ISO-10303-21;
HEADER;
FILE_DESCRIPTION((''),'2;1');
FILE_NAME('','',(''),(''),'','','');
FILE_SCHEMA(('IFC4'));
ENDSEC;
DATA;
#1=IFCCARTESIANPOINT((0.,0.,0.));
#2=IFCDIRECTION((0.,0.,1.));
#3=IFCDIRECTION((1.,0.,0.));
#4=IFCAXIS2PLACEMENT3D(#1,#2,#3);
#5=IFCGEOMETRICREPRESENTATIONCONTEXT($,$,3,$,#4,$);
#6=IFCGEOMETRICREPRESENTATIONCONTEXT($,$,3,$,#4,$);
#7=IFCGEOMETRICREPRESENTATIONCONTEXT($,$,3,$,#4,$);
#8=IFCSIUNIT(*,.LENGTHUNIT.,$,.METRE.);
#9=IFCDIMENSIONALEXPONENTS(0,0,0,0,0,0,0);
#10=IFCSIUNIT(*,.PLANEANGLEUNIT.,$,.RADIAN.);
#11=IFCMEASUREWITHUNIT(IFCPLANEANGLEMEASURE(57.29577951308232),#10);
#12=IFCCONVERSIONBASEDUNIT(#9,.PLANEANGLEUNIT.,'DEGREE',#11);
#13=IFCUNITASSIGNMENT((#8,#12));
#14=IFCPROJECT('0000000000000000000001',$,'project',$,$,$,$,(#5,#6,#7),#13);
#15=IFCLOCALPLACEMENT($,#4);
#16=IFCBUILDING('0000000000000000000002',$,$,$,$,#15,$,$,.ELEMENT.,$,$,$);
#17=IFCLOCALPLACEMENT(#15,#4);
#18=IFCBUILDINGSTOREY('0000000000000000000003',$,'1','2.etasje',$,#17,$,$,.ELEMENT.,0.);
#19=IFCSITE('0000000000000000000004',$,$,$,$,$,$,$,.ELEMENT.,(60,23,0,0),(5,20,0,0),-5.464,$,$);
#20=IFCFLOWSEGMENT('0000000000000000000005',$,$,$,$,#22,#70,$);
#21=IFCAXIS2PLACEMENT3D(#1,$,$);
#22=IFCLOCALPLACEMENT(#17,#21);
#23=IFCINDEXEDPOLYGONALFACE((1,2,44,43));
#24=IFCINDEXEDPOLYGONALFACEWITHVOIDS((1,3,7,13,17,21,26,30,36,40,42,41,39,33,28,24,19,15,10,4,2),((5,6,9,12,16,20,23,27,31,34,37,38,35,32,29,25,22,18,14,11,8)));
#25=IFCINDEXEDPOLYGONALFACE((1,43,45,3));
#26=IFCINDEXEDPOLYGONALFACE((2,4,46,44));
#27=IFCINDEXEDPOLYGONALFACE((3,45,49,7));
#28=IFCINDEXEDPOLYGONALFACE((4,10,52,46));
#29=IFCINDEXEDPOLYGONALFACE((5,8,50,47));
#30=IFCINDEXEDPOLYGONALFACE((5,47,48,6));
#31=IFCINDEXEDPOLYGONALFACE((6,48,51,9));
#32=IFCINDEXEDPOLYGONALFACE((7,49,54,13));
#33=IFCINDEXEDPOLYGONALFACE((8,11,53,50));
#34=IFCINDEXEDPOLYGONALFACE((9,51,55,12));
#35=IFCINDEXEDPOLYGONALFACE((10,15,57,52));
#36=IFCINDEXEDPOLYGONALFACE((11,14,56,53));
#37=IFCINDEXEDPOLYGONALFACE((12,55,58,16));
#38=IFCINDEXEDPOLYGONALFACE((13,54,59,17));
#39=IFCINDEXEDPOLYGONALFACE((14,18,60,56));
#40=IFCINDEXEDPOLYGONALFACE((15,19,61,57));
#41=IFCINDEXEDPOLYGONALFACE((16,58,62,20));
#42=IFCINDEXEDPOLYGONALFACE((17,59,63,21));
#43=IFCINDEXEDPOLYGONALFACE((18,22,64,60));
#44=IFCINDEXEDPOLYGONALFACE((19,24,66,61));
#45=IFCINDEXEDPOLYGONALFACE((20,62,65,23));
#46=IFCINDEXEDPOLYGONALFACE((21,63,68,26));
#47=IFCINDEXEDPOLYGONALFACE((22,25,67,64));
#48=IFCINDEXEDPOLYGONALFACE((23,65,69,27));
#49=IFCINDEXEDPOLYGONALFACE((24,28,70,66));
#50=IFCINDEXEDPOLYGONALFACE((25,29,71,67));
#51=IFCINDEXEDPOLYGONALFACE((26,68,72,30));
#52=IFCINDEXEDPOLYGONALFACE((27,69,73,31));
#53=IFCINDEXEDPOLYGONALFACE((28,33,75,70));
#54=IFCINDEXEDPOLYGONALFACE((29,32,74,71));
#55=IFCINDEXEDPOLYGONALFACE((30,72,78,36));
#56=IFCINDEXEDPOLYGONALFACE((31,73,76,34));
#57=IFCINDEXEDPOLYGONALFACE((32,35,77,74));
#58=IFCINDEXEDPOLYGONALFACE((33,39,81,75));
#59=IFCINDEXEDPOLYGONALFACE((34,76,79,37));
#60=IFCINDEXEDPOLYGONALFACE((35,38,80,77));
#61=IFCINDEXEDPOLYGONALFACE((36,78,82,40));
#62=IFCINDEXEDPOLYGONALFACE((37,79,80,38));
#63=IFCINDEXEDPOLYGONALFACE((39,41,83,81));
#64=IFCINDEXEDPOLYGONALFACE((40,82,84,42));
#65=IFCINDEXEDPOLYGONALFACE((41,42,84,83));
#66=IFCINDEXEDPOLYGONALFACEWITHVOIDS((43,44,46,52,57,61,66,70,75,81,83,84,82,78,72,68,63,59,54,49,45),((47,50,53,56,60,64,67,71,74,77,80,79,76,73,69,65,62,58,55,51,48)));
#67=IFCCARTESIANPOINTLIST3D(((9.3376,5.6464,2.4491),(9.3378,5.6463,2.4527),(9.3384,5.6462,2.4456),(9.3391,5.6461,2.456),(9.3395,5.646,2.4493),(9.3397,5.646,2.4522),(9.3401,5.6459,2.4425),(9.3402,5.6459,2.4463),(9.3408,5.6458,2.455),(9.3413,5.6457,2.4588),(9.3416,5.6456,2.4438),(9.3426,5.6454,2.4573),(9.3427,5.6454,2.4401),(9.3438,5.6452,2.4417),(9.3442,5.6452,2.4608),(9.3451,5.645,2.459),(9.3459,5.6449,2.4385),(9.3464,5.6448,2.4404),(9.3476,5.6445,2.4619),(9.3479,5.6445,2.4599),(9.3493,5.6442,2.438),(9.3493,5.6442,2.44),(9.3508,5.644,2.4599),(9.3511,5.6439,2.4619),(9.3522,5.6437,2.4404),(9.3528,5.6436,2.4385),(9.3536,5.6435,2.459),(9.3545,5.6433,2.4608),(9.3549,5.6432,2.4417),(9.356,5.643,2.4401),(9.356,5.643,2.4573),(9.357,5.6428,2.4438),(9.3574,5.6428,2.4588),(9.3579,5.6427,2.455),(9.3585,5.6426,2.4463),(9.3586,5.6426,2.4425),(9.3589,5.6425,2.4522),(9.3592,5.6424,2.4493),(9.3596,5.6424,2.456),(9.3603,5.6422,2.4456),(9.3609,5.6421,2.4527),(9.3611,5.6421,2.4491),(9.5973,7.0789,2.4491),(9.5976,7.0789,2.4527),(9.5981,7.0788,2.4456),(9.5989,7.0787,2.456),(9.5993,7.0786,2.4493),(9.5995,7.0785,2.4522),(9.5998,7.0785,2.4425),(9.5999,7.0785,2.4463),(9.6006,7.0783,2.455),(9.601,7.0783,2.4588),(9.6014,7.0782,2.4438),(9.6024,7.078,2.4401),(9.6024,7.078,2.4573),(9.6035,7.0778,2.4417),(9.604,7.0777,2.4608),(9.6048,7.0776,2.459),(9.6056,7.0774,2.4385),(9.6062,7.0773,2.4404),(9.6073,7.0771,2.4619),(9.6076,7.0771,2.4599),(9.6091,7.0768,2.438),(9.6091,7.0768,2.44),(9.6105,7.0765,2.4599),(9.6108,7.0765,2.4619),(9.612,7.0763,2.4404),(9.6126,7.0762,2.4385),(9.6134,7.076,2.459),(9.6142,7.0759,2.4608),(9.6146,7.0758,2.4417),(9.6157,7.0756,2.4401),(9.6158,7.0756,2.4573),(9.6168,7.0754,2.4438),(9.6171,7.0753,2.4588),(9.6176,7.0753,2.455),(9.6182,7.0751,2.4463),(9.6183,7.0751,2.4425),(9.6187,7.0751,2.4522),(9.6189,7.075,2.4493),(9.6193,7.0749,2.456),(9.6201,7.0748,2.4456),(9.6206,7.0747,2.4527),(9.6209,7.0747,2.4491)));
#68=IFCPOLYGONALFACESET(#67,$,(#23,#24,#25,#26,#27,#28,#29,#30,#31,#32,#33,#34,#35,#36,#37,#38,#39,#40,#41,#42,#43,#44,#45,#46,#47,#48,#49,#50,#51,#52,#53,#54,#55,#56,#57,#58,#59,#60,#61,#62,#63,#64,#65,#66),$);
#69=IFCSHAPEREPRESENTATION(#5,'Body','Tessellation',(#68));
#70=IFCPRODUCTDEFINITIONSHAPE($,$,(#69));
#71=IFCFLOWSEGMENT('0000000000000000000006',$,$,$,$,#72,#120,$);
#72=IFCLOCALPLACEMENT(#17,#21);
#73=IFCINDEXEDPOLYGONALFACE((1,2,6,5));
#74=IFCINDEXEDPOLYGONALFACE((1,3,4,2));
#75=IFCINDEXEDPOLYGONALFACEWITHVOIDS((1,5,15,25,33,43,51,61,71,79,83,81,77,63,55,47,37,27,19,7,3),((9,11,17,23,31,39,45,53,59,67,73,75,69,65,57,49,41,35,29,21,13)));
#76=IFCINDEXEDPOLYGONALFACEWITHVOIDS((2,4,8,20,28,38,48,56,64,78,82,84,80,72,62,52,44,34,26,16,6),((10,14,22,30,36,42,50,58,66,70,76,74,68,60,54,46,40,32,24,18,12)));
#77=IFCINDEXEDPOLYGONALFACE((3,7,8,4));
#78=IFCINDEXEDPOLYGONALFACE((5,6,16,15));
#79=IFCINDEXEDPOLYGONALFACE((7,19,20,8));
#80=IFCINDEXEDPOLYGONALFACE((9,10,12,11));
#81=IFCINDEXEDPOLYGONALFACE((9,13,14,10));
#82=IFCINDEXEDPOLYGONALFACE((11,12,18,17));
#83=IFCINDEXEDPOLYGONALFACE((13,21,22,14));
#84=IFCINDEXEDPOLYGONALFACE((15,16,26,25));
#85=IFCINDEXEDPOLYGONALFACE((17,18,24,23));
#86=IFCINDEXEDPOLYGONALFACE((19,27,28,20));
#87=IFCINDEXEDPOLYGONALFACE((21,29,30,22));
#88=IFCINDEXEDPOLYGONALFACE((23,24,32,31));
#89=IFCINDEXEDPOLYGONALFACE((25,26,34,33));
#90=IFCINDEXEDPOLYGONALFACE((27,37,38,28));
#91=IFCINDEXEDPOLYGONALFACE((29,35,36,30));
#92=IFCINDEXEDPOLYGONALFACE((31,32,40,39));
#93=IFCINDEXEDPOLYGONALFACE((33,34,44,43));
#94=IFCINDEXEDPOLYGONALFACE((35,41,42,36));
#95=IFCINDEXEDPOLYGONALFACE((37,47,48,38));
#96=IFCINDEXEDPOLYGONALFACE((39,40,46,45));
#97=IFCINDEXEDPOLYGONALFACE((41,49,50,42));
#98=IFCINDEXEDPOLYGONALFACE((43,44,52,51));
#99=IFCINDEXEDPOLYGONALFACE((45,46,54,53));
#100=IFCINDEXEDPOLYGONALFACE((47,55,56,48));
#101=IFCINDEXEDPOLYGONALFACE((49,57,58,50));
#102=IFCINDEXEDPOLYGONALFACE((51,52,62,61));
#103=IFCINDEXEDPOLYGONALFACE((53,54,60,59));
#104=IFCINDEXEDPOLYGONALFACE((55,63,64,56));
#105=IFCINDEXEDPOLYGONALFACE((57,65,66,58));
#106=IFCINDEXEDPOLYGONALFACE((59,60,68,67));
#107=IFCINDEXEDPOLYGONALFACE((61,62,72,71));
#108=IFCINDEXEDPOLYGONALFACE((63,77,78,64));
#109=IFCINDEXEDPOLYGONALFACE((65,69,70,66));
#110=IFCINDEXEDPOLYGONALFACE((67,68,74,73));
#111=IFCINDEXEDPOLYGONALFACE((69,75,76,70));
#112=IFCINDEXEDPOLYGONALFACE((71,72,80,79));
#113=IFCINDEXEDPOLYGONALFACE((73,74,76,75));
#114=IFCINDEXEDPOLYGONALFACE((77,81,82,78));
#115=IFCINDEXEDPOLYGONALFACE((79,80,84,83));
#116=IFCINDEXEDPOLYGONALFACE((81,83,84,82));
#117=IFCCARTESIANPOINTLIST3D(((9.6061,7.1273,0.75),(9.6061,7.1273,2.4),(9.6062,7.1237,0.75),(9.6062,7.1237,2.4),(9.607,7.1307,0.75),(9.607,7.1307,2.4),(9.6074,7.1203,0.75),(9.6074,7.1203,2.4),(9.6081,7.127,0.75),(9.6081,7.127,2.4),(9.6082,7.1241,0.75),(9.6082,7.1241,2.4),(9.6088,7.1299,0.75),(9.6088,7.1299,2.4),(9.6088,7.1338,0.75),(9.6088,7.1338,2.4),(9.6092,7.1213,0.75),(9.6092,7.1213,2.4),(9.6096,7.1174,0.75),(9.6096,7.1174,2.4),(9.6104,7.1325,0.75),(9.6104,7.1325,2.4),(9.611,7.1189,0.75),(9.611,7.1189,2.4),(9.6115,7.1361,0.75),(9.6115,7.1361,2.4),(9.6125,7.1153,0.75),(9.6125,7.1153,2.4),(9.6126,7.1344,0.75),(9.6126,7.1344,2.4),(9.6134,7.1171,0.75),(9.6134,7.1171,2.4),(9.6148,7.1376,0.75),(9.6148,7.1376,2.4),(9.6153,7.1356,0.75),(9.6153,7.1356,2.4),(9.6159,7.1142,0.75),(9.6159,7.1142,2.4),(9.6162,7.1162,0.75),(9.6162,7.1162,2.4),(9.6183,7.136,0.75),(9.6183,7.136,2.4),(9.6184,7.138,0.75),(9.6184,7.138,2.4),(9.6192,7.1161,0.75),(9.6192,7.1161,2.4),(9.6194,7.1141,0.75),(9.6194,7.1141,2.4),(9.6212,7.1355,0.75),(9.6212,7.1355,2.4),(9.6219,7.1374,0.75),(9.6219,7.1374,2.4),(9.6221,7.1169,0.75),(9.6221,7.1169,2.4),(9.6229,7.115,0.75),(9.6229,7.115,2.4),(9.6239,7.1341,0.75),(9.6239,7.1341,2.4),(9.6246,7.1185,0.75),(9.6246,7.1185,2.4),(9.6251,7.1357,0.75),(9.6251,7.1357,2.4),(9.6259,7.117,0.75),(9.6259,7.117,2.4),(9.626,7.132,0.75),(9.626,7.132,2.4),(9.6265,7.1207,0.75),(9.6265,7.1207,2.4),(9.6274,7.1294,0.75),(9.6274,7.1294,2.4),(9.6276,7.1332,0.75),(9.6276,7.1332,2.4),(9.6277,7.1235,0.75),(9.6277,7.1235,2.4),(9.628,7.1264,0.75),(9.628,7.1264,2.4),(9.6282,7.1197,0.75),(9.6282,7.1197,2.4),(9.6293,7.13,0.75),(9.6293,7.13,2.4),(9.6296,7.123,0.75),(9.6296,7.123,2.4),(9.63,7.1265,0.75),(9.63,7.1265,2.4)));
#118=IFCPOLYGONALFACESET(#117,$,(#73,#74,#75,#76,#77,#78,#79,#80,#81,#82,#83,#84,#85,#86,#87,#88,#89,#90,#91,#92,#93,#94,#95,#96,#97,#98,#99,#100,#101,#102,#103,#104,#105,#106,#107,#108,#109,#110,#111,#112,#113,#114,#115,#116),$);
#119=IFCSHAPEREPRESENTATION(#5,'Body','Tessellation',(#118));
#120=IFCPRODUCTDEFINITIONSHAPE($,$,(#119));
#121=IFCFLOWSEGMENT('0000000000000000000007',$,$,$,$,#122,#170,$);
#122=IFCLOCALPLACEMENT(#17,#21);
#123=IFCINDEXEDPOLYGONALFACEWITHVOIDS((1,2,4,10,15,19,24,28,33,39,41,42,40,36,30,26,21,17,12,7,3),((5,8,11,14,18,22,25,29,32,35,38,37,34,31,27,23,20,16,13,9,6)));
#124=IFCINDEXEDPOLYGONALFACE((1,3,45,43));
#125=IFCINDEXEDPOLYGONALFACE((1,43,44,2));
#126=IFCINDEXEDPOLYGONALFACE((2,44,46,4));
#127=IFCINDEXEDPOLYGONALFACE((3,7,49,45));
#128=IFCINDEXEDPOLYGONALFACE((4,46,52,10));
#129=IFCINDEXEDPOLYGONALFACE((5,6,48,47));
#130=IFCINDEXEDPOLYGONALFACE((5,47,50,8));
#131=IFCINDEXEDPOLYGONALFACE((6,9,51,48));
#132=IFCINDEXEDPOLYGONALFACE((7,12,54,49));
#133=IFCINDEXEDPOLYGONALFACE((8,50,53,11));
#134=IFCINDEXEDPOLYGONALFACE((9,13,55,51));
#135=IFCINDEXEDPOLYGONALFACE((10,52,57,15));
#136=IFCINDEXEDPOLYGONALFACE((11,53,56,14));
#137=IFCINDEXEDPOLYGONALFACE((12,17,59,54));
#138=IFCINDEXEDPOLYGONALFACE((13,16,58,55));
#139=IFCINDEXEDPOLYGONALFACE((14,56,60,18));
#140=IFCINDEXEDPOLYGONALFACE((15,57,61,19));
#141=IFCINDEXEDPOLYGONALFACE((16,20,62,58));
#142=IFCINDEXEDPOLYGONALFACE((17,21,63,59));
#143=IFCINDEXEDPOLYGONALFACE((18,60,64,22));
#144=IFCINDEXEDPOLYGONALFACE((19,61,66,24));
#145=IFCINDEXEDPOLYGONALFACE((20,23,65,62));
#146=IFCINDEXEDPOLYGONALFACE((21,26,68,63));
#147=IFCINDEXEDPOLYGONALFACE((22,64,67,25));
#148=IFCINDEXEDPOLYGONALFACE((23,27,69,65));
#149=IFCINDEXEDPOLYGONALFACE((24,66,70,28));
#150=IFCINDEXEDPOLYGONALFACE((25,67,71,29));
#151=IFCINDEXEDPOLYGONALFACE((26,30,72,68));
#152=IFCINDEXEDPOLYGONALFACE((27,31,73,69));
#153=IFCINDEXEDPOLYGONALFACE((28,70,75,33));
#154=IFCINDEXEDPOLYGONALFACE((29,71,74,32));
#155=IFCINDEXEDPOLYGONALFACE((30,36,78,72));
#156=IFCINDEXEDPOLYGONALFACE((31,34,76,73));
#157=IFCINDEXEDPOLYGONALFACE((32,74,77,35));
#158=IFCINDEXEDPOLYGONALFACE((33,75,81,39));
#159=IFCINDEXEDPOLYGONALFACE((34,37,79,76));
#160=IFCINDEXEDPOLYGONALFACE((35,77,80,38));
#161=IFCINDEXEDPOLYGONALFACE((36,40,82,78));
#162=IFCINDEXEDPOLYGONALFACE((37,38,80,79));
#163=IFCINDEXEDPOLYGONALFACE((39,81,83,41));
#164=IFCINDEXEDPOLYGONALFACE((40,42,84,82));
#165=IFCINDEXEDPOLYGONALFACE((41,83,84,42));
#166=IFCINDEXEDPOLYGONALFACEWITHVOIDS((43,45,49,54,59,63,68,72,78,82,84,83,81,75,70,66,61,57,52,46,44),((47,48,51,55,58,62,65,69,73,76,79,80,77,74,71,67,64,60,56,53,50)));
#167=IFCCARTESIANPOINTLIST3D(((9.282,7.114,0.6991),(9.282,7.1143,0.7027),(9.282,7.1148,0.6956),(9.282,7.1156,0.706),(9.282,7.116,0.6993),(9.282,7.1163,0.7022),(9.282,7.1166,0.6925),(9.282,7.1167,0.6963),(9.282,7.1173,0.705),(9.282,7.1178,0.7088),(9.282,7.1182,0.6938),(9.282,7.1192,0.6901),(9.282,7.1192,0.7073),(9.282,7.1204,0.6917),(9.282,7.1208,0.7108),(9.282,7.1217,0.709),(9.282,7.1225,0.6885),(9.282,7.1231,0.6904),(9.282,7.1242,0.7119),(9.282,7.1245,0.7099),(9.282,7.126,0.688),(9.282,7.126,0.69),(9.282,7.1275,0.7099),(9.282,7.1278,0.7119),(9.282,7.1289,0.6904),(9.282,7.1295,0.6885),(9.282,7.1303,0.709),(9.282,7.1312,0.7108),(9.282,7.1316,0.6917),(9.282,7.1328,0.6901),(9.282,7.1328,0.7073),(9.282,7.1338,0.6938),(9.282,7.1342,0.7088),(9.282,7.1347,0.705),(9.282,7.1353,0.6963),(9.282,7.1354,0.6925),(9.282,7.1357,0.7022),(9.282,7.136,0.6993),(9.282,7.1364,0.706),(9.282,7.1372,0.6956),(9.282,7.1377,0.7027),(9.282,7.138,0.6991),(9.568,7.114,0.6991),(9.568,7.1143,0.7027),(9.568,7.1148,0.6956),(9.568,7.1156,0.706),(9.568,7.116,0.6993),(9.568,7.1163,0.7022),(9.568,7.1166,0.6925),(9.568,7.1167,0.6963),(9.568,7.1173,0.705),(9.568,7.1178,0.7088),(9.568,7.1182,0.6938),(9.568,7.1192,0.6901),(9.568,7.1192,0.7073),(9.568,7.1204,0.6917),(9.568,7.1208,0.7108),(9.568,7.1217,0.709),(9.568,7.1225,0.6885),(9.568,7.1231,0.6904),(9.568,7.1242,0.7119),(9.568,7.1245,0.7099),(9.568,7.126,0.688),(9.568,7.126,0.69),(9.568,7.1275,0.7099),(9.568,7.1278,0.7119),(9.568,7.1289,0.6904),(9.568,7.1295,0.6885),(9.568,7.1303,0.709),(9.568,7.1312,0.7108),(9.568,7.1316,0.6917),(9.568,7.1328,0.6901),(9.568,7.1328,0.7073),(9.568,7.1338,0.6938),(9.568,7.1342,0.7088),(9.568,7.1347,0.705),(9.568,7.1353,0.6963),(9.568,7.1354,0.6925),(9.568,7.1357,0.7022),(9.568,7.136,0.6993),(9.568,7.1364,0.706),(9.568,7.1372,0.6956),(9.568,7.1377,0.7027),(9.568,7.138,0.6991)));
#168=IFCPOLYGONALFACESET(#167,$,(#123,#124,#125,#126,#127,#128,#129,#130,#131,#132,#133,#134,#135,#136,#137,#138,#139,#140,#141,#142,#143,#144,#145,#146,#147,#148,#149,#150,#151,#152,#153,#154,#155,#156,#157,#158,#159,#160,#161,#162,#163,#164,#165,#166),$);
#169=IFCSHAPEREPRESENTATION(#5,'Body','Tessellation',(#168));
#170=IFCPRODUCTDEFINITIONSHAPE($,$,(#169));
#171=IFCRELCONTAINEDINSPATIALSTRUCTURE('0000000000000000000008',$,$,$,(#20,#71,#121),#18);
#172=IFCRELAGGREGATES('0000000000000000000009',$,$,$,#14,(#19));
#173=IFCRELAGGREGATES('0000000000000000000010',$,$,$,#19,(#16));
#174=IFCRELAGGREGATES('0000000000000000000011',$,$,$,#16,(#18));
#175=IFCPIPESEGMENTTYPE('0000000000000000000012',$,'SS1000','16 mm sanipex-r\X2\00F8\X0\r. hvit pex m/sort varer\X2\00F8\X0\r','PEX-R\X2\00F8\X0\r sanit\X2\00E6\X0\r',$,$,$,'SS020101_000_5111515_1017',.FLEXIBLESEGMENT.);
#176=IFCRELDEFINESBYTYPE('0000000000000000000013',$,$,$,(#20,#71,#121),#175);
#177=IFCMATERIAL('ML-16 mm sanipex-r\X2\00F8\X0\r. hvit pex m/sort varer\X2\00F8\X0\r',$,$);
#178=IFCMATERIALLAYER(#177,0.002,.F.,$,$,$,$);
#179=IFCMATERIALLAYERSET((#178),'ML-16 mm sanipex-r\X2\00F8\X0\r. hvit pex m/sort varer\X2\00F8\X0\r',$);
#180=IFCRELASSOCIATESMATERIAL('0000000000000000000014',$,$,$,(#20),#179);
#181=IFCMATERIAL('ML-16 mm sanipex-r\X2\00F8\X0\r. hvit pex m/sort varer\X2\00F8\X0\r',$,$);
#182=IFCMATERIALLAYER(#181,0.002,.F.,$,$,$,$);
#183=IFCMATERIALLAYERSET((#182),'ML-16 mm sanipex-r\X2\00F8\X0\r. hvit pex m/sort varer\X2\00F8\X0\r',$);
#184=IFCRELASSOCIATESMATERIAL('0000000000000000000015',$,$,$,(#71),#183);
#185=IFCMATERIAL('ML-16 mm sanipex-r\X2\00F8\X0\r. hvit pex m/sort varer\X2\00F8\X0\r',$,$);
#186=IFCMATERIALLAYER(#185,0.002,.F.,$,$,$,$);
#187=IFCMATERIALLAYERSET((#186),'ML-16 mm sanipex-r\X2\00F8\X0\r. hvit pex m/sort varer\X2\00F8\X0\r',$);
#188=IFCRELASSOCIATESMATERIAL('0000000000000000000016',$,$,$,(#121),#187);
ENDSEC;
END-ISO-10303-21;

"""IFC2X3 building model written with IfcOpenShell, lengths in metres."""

from ifc_helpers import new_model, entity, si_unit, converted_unit, frame, origin_with_axes, origin_2d_with_axis, place, context, project, spatial, hollow_circle, extrude, material, layer, layer_set, layer_usage, type_object, element, save


model = new_model("IFC2X3")

# Units and contexts
context_of_model_1 = context(None, 3, world=origin_with_axes())
context_of_model_2 = context(None, 3, world=origin_with_axes())
context_of_model_3 = context(None, 3, world=origin_with_axes())
ifc_project = project(units=[si_unit("LENGTHUNIT", "METRE"), converted_unit("PLANEANGLEUNIT", "DEGREE", entity("IfcPlaneAngleMeasure", 57.29577951308232), si_unit("PLANEANGLEUNIT", "RADIAN"), dimensions=[0, 0, 0, 0, 0, 0, 0])], contexts=[context_of_model_1, context_of_model_2, context_of_model_3])

# Site, building, storey
site = spatial("IfcSite", under=ifc_project, CompositionType="ELEMENT", RefLatitude=(60, 23, 0, 0), RefLongitude=(5, 20, 0, 0), RefElevation=-5.464)
building_placement = place(None, origin_with_axes())
building = spatial("IfcBuilding", under=site, at=building_placement, CompositionType="ELEMENT")
storey_placement = place(building_placement, origin_with_axes())
storey = spatial("IfcBuildingStorey", under=building, at=storey_placement, Name="1", Description="2.etasje", CompositionType="ELEMENT", Elevation=0.0)

# Flow segments
ifc_material_1 = material(Name="ML-16 mm sanipex-rør. hvit pex m/sort varerør")
ifc_layer_1 = layer(ifc_material_1, 0.002, ventilated=False)
ifc_layer_set_1 = layer_set([ifc_layer_1], Name="ML-16 mm sanipex-rør. hvit pex m/sort varerør")
ifc_layer_usage_1 = layer_usage(ifc_layer_set_1, "AXIS2", "POSITIVE", 0.0)
pipe_segment_type_1 = type_object("IfcPipeSegmentType", Name="SS1000", Description="16 mm sanipex-rør. hvit pex m/sort varerør", ApplicableOccurrence="PEX-Rør sanitær", ElementType="SS020101_000_5111515_1017", PredefinedType="FLEXIBLESEGMENT")
flow_segment_1_placement = place(storey_placement, frame((9.3493, 5.6442, 2.45), z_axis=(0.1784, 0.983958, 0.0), x_axis=(0.0, 0.0, -1.0)))
element("IfcFlowSegment", 1, at=flow_segment_1_placement, inside=storey, type_object=pipe_segment_type_1, material=ifc_layer_usage_1, context=context_of_model_1, shape_type="SweptSolid", body=[
    extrude(hollow_circle(Radius=0.012, WallThickness=0.002, at=origin_2d_with_axis()), origin_with_axes(), (0.0, 0.0, 1.0), 1.4559),
])
ifc_material_2 = material(Name="ML-16 mm sanipex-rør. hvit pex m/sort varerør")
ifc_layer_2 = layer(ifc_material_2, 0.002, ventilated=False)
ifc_layer_set_2 = layer_set([ifc_layer_2], Name="ML-16 mm sanipex-rør. hvit pex m/sort varerør")
ifc_layer_usage_2 = layer_usage(ifc_layer_set_2, "AXIS2", "POSITIVE", 0.0)
flow_segment_2_placement = place(storey_placement, frame((9.618, 7.126, 2.4), z_axis=(0.0, 0.0, -1.0), x_axis=(-0.1784, -0.983958, 0.0)))
element("IfcFlowSegment", 2, at=flow_segment_2_placement, inside=storey, type_object=pipe_segment_type_1, material=ifc_layer_usage_2, context=context_of_model_1, shape_type="SweptSolid", body=[
    extrude(hollow_circle(Radius=0.012, WallThickness=0.002, at=origin_2d_with_axis()), origin_with_axes(), (0.0, 0.0, 1.0), 1.65),
])
ifc_material_3 = material(Name="ML-16 mm sanipex-rør. hvit pex m/sort varerør")
ifc_layer_3 = layer(ifc_material_3, 0.002, ventilated=False)
ifc_layer_set_3 = layer_set([ifc_layer_3], Name="ML-16 mm sanipex-rør. hvit pex m/sort varerør")
ifc_layer_usage_3 = layer_usage(ifc_layer_set_3, "AXIS2", "POSITIVE", 0.0)
flow_segment_3_placement = place(storey_placement, frame((9.568, 7.126, 0.7), z_axis=(-1.0, 0.0, 0.0), x_axis=(0.0, 0.0, -1.0)))
element("IfcFlowSegment", 3, at=flow_segment_3_placement, inside=storey, type_object=pipe_segment_type_1, material=ifc_layer_usage_3, context=context_of_model_1, shape_type="SweptSolid", body=[
    extrude(hollow_circle(Radius=0.012, WallThickness=0.002, at=origin_2d_with_axis()), origin_with_axes(), (0.0, 0.0, 1.0), 0.286),
])

save(model, "model.ifc")
